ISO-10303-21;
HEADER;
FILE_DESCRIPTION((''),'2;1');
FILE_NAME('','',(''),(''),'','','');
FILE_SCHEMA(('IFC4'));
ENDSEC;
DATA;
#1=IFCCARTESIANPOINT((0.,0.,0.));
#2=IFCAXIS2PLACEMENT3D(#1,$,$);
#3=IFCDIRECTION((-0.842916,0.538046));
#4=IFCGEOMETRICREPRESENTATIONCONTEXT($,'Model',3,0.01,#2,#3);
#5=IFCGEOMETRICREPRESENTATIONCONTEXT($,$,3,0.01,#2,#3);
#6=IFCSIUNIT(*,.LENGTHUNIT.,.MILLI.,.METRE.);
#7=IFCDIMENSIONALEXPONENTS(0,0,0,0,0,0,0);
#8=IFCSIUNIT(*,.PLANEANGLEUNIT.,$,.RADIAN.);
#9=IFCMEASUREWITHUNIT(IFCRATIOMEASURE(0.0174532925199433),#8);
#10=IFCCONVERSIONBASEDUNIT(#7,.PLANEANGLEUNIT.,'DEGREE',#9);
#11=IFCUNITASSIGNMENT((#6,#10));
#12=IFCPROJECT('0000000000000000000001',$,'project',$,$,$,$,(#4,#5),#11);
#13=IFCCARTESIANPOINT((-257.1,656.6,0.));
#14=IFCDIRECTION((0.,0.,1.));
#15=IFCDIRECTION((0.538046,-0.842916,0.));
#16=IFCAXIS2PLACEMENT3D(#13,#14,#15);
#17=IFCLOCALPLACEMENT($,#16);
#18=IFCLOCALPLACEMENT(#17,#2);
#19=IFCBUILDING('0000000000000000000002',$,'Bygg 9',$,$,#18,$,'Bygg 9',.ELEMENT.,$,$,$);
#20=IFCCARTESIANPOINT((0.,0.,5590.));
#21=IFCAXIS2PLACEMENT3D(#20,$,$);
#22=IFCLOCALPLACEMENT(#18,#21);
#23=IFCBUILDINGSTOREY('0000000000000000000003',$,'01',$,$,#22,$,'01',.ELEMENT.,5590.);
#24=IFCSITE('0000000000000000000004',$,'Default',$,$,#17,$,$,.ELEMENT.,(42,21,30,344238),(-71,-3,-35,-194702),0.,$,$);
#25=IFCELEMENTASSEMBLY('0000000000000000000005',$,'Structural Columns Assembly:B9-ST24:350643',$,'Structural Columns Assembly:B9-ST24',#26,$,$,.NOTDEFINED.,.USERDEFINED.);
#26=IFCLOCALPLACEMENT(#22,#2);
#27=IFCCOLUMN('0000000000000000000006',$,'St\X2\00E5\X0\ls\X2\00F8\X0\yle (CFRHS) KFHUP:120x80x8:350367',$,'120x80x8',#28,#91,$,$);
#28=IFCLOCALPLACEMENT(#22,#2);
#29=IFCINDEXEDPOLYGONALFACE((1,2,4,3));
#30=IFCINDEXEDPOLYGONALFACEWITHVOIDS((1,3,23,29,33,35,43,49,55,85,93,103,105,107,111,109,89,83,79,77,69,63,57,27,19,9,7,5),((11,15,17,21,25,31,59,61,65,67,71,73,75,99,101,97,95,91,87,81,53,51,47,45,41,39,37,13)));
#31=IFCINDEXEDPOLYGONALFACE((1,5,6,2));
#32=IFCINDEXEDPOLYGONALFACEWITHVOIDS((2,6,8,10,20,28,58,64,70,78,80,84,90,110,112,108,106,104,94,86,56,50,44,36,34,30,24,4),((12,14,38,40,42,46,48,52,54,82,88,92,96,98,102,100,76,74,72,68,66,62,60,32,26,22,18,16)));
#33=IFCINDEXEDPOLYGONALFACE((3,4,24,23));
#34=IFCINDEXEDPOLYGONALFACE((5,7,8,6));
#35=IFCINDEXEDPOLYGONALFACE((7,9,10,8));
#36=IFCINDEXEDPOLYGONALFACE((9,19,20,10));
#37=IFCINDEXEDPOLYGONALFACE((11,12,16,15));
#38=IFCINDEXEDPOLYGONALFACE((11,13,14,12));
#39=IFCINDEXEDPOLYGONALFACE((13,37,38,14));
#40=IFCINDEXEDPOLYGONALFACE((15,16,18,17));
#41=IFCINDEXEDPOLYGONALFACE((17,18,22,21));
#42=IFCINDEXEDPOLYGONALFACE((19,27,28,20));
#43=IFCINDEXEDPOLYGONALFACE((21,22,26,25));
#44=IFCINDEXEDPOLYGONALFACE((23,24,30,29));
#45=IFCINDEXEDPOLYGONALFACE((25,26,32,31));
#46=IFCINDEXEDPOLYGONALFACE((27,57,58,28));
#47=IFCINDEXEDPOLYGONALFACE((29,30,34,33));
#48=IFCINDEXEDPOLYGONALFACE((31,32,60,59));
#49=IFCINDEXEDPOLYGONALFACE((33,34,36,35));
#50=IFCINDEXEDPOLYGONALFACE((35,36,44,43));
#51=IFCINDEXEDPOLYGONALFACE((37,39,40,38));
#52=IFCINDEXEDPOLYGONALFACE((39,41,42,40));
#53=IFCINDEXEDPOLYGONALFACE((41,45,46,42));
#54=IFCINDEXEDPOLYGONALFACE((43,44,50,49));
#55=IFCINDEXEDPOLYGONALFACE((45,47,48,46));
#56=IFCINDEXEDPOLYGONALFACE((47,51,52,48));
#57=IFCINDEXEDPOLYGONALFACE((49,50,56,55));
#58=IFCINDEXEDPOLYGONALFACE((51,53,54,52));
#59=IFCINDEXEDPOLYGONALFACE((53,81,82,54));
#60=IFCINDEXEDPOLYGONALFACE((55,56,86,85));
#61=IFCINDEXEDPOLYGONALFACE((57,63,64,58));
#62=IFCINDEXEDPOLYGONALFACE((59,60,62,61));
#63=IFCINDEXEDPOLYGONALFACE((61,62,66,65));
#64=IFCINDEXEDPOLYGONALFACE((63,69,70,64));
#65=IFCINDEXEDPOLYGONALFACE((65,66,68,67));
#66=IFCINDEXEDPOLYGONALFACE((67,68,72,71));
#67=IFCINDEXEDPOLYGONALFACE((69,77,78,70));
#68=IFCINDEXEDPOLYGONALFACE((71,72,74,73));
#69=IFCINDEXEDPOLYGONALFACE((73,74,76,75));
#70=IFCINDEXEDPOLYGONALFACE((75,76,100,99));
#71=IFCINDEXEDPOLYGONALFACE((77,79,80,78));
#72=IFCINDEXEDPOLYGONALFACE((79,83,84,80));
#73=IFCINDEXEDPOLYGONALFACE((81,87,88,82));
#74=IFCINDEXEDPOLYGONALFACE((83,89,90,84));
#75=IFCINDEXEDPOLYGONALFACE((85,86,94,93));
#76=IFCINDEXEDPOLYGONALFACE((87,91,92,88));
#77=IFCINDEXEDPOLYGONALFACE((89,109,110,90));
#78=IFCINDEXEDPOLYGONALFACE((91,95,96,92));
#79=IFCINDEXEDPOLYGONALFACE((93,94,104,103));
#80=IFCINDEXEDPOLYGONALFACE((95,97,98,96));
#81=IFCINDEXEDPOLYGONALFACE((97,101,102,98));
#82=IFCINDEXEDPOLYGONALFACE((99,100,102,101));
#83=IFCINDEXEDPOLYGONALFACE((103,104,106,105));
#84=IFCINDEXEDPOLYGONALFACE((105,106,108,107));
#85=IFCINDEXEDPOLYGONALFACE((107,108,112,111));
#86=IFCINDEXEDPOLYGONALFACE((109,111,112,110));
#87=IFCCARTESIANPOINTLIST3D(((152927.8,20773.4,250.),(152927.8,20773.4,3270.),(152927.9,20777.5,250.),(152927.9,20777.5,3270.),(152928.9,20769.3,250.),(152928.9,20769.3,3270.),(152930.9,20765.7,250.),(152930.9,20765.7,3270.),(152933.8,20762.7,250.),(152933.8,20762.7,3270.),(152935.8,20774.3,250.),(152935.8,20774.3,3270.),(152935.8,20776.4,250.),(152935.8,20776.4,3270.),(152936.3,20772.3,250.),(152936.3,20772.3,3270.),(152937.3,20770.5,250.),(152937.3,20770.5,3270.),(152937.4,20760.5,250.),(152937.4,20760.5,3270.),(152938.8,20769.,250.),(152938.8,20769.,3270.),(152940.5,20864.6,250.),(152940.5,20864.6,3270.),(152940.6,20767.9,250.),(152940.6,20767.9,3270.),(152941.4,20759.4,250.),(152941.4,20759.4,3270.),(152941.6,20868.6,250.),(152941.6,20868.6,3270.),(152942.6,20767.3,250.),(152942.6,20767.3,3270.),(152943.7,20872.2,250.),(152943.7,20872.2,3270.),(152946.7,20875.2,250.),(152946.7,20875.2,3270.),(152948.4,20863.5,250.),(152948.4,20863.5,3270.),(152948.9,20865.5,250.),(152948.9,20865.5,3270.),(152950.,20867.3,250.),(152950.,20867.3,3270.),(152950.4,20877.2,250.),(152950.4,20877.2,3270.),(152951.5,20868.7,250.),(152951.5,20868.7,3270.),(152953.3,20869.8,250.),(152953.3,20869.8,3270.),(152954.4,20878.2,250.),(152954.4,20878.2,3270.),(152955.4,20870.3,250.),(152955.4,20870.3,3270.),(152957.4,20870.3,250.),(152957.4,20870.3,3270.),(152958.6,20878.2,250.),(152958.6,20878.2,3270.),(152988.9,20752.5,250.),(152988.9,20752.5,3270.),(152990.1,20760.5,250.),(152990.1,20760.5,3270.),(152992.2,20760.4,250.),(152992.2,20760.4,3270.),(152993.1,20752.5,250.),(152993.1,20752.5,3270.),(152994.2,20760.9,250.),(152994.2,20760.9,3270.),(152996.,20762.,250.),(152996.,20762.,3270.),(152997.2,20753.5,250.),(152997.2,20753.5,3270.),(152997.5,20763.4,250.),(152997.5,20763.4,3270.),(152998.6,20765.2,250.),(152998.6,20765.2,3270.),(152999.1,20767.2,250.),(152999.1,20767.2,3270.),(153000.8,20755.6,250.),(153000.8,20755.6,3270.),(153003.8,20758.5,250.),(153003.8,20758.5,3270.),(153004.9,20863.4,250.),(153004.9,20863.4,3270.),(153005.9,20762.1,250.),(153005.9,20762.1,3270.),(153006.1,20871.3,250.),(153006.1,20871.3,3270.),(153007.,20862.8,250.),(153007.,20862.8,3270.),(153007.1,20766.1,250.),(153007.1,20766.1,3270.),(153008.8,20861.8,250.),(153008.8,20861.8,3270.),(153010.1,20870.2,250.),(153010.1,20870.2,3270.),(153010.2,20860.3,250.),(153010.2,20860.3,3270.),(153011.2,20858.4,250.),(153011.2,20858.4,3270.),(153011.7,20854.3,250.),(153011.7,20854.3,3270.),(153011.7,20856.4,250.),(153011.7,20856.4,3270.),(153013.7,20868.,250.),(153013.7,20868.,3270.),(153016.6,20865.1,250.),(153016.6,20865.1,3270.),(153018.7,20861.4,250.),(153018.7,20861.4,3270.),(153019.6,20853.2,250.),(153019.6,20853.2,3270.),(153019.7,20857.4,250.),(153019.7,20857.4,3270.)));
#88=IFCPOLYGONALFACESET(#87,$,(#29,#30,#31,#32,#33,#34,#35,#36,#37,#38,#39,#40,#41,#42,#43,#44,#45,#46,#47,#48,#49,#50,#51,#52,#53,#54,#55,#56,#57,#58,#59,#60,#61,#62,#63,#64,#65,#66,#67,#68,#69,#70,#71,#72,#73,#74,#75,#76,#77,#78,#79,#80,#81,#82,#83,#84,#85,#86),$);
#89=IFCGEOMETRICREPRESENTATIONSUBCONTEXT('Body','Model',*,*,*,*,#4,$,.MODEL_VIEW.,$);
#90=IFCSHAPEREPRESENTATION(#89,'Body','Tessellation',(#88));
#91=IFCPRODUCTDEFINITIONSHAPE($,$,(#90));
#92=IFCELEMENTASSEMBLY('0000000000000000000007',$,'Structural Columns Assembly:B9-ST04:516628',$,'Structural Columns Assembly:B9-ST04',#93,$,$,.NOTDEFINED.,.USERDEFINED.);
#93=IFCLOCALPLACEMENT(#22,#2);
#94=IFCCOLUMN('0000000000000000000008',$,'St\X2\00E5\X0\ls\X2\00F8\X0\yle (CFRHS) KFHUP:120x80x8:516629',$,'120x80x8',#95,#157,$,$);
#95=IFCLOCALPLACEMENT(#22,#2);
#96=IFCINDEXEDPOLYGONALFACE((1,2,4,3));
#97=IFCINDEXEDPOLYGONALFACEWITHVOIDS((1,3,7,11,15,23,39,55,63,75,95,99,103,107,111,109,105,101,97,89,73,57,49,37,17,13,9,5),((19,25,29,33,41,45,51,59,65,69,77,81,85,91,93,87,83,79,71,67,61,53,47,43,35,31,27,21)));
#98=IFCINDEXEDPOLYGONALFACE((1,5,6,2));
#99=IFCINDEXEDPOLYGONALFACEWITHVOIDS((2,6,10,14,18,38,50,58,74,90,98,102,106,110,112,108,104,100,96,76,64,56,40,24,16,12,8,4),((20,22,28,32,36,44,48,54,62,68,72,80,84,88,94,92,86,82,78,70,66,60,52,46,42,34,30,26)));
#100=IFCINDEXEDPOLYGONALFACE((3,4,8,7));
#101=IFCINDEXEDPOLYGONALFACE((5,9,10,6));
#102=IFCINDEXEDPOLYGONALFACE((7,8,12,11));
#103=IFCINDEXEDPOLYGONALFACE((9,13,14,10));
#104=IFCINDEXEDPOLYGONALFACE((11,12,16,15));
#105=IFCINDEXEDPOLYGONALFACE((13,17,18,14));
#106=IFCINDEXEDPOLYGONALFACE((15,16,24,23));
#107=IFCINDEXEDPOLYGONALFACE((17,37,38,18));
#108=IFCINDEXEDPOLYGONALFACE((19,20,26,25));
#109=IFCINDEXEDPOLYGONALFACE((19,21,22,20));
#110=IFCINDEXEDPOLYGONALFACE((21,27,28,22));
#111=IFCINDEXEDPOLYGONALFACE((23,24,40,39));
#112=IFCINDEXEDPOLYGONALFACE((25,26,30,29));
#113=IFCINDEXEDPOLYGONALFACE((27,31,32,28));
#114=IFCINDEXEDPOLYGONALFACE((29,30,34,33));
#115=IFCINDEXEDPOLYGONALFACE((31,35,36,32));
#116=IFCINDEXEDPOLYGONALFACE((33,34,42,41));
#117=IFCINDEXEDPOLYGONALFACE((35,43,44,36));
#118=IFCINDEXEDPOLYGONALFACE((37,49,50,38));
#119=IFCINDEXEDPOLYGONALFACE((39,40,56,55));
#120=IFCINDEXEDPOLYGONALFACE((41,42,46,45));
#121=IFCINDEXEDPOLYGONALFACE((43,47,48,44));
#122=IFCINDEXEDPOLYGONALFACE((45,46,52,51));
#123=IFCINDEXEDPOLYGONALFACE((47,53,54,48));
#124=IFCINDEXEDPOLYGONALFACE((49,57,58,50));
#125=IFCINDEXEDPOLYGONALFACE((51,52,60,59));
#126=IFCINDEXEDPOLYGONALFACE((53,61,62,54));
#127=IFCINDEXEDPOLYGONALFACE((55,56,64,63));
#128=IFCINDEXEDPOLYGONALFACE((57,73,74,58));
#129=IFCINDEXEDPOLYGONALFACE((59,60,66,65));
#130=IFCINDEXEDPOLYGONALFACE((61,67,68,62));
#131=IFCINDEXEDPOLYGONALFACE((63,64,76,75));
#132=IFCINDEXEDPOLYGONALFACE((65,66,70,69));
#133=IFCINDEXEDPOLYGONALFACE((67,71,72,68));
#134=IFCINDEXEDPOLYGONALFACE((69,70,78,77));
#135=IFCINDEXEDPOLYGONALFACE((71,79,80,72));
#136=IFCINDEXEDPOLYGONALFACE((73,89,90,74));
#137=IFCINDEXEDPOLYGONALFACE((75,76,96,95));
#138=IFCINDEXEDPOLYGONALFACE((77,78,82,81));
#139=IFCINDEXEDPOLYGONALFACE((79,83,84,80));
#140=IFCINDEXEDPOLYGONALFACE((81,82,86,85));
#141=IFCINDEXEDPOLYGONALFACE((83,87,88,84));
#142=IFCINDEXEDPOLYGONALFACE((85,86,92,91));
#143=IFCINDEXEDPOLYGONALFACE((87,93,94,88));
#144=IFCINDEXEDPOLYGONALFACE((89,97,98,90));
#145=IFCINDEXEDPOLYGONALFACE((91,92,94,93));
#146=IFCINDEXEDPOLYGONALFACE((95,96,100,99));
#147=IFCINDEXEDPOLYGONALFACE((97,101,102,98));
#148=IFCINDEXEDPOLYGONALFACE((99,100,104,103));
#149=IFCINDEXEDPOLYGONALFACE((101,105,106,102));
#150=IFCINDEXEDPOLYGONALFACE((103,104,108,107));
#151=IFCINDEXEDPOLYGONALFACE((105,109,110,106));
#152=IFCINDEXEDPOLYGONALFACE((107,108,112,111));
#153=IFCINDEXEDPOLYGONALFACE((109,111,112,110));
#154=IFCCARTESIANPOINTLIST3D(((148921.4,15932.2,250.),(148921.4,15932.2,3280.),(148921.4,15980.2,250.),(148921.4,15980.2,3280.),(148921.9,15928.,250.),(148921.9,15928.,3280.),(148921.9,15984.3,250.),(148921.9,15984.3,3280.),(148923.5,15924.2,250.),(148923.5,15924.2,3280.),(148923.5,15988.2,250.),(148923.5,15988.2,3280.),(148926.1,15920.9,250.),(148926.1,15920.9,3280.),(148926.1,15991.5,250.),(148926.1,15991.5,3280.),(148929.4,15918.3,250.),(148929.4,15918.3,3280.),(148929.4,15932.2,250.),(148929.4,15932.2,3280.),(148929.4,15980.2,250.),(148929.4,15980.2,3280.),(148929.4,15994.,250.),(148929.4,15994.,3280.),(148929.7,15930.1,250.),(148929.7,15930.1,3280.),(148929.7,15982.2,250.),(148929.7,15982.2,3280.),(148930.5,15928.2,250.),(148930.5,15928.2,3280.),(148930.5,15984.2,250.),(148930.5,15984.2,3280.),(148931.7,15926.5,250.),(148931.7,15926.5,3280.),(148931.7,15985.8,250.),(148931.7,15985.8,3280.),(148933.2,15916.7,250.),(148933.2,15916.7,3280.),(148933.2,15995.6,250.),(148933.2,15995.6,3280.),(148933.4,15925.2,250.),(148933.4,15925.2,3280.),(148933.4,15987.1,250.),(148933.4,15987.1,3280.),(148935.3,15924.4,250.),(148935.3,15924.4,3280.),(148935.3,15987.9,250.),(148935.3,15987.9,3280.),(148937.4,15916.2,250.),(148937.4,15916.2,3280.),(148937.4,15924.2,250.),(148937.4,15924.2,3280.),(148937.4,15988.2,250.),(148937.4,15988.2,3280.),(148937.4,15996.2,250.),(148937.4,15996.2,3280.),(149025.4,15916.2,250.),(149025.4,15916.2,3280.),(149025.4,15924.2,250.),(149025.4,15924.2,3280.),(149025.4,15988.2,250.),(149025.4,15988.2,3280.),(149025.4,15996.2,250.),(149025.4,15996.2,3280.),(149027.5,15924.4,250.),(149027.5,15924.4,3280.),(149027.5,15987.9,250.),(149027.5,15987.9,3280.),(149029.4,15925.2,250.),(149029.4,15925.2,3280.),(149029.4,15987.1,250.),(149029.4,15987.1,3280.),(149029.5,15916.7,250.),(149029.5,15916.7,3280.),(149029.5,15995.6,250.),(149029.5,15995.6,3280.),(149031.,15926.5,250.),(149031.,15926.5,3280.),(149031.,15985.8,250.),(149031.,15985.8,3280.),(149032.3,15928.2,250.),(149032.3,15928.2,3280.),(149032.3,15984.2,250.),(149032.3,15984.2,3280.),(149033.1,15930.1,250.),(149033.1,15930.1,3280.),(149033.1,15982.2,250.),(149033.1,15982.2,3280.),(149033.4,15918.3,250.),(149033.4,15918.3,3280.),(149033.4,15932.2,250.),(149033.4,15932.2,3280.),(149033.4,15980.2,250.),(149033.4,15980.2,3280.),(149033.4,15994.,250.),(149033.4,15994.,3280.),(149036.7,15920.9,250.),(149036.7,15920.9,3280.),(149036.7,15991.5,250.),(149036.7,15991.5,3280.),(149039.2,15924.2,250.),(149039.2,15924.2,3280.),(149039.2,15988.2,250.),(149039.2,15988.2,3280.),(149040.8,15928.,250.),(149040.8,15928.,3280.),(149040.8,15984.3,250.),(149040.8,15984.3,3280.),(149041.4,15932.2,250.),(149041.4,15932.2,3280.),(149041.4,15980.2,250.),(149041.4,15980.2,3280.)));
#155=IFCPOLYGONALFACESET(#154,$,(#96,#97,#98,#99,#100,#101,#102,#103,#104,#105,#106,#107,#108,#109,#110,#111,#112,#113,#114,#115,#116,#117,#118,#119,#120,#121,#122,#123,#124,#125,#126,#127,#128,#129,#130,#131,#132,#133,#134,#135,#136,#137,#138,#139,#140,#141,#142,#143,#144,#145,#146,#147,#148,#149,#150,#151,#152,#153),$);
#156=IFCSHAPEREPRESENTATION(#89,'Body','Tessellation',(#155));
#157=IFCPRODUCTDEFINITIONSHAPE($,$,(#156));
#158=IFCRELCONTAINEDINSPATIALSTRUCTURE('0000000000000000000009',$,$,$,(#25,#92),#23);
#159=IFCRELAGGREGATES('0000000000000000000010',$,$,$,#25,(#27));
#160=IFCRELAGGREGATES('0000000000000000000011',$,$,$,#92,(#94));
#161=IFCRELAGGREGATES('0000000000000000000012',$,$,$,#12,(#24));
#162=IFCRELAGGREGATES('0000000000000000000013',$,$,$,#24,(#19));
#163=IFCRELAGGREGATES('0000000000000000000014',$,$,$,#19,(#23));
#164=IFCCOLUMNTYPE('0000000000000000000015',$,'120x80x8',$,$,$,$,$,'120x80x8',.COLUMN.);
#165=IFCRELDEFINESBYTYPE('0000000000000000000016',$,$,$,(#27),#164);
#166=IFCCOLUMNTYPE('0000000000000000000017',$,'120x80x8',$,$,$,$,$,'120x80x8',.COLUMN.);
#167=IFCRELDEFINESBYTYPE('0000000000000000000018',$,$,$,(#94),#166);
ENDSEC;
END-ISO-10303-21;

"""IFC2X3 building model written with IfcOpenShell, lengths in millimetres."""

from ifc_helpers import new_model, entity, si_unit, converted_unit, direction, frame, frame_2d, origin, place, context, subcontext, project, spatial, polyline, circle_curve, parameter, trimmed, segment, composite_curve, outline, extrude, source, transform, mapped, type_object, type_shapes, element, aggregate, save


model = new_model("IFC2X3")

# Units and contexts
model_context = context("Model", 3, precision=0.01, world=origin(), true_north=direction((-0.842916, 0.538046)))
context_of_model = context(None, 3, precision=0.01, world=origin(), true_north=direction((-0.842916, 0.538046)))
body_context = subcontext(model_context, "Body", "Model", "MODEL_VIEW")
ifc_project = project(units=[si_unit("LENGTHUNIT", "METRE", prefix="MILLI"), converted_unit("PLANEANGLEUNIT", "DEGREE", entity("IfcRatioMeasure", 0.0174532925199433), si_unit("PLANEANGLEUNIT", "RADIAN"), dimensions=[0, 0, 0, 0, 0, 0, 0])], contexts=[model_context, context_of_model])

# Site, building, storey
site_placement = place(None, frame((-257.1, 656.6, 0.0), z_axis=(0.0, 0.0, 1.0), x_axis=(0.538046, -0.842916, 0.0)))
site = spatial("IfcSite", under=ifc_project, at=site_placement, Name="Default", CompositionType="ELEMENT", RefLatitude=(42, 21, 30, 344238), RefLongitude=(-71, -3, -35, -194702), RefElevation=0.0)
building_placement = place(site_placement, origin())
building = spatial("IfcBuilding", under=site, at=building_placement, Name="Bygg 9", LongName="Bygg 9", CompositionType="ELEMENT")
storey_placement = place(building_placement, frame((0.0, 0.0, 5590.0)))
storey = spatial("IfcBuildingStorey", under=building, at=storey_placement, Name="01", LongName="01", CompositionType="ELEMENT", Elevation=5590.0)

# Element assemblies, columns
assembly_1_placement = place(storey_placement, origin())
assembly_1 = element("IfcElementAssembly", 1, at=assembly_1_placement, inside=storey, Name="Structural Columns Assembly:B9-ST24:350643", ObjectType="Structural Columns Assembly:B9-ST24", AssemblyPlace="NOTDEFINED", PredefinedType="USERDEFINED")
column_type_1 = type_object("IfcColumnType", Name="120x80x8", ElementType="120x80x8", PredefinedType="COLUMN")
shared_shape_1 = source(origin(), body_context, "Body", "SweptSolid", [
    extrude(outline(composite_curve([segment(polyline([(-24.0, -60.0), (24.0, -60.0)]), True, "CONTINUOUS"), segment(trimmed(circle_curve(frame_2d((24.0, -44.0), x_axis=(-1.0, 0.0)), 16.0), [parameter(90.0)], [parameter(180.0)], True, "PARAMETER"), True, "CONTINUOUS"), segment(polyline([(40.0, -44.0), (40.0, 44.0)]), True, "CONTINUOUS"), segment(trimmed(circle_curve(frame_2d((24.0, 44.0), x_axis=(-1.0, 0.0)), 16.0), [parameter(180.0)], [parameter(270.0)], True, "PARAMETER"), True, "CONTINUOUS"), segment(polyline([(24.0, 60.0), (-24.0, 60.0)]), True, "CONTINUOUS"), segment(trimmed(circle_curve(frame_2d((-24.0, 44.0), x_axis=(-1.0, 0.0)), 16.0), [parameter(270.0)], [parameter(0.0)], True, "PARAMETER"), True, "CONTINUOUS"), segment(polyline([(-40.0, 44.0), (-40.0, -44.0)]), True, "CONTINUOUS"), segment(trimmed(circle_curve(frame_2d((-24.0, -44.0), x_axis=(-1.0, 0.0)), 16.0), [parameter(0.0)], [parameter(90.0)], True, "PARAMETER"), True, "CONTINUOUS")], self_intersect=False), holes=[composite_curve([segment(trimmed(circle_curve(frame_2d((24.0, -44.0), x_axis=(-1.0, 0.0)), 8.0), [parameter(90.0)], [parameter(180.0)], True, "PARAMETER"), False, "CONTINUOUS"), segment(polyline([(24.0, -52.0), (-24.0, -52.0)]), True, "CONTINUOUS"), segment(trimmed(circle_curve(frame_2d((-24.0, -44.0), x_axis=(-1.0, 0.0)), 8.0), [parameter(360.0)], [parameter(90.0)], True, "PARAMETER"), False, "CONTINUOUS"), segment(polyline([(-32.0, -44.0), (-32.0, 44.0)]), True, "CONTINUOUS"), segment(trimmed(circle_curve(frame_2d((-24.0, 44.0), x_axis=(-1.0, 0.0)), 8.0), [parameter(270.0)], [parameter(360.0)], True, "PARAMETER"), False, "CONTINUOUS"), segment(polyline([(-24.0, 52.0), (24.0, 52.0)]), True, "CONTINUOUS"), segment(trimmed(circle_curve(frame_2d((24.0, 44.0), x_axis=(-1.0, 0.0)), 8.0), [parameter(180.0)], [parameter(270.0)], True, "PARAMETER"), False, "CONTINUOUS"), segment(polyline([(32.0, 44.0), (32.0, -44.0)]), True, "CONTINUOUS")], self_intersect=False)]), frame((47.5, 64.4, 0.0), z_axis=(0.0, 0.0, 1.0), x_axis=(0.989719, -0.143028, 0.0)), (0.0, 0.0, 1.0), 3020.0),
])
type_shapes(column_type_1, [shared_shape_1])
column_1_placement = place(assembly_1_placement, frame((152926.3, 20750.9, 250.0)))
column_1 = element("IfcColumn", 2, at=column_1_placement, type_object=column_type_1, Name="Stålsøyle (CFRHS) KFHUP:120x80x8:350367", ObjectType="120x80x8", context=body_context, shape_type="MappedRepresentation", body=[
    mapped(shared_shape_1, transform((0.0, 0.0, 0.0), scale=1.0)),
])
aggregate(assembly_1, [column_1])
assembly_2_placement = place(storey_placement, origin())
assembly_2 = element("IfcElementAssembly", 3, at=assembly_2_placement, inside=storey, Name="Structural Columns Assembly:B9-ST04:516628", ObjectType="Structural Columns Assembly:B9-ST04", AssemblyPlace="NOTDEFINED", PredefinedType="USERDEFINED")
column_type_2 = type_object("IfcColumnType", Name="120x80x8", ElementType="120x80x8", PredefinedType="COLUMN")
shared_shape_2 = source(origin(), body_context, "Body", "SweptSolid", [
    extrude(outline(composite_curve([segment(trimmed(circle_curve(frame_2d((-24.0, 44.0), x_axis=(1.0, 0.0)), 16.0), [parameter(90.0)], [parameter(180.0)], True, "PARAMETER"), True, "CONTINUOUS"), segment(polyline([(-40.0, 44.0), (-40.0, -44.0)]), True, "CONTINUOUS"), segment(trimmed(circle_curve(frame_2d((-24.0, -44.0), x_axis=(1.0, 0.0)), 16.0), [parameter(180.0)], [parameter(270.0)], True, "PARAMETER"), True, "CONTINUOUS"), segment(polyline([(-24.0, -60.0), (24.0, -60.0)]), True, "CONTINUOUS"), segment(trimmed(circle_curve(frame_2d((24.0, -44.0), x_axis=(1.0, 0.0)), 16.0), [parameter(270.0)], [parameter(0.0)], True, "PARAMETER"), True, "CONTINUOUS"), segment(polyline([(40.0, -44.0), (40.0, 44.0)]), True, "CONTINUOUS"), segment(trimmed(circle_curve(frame_2d((24.0, 44.0), x_axis=(1.0, 0.0)), 16.0), [parameter(0.0)], [parameter(90.0)], True, "PARAMETER"), True, "CONTINUOUS"), segment(polyline([(24.0, 60.0), (-24.0, 60.0)]), True, "CONTINUOUS")], self_intersect=False), holes=[composite_curve([segment(polyline([(-24.0, 52.0), (24.0, 52.0)]), True, "CONTINUOUS"), segment(trimmed(circle_curve(frame_2d((24.0, 44.0), x_axis=(1.0, 0.0)), 8.0), [parameter(360.0)], [parameter(90.0)], True, "PARAMETER"), False, "CONTINUOUS"), segment(polyline([(32.0, 44.0), (32.0, -44.0)]), True, "CONTINUOUS"), segment(trimmed(circle_curve(frame_2d((24.0, -44.0), x_axis=(1.0, 0.0)), 8.0), [parameter(270.0)], [parameter(360.0)], True, "PARAMETER"), False, "CONTINUOUS"), segment(polyline([(24.0, -52.0), (-24.0, -52.0)]), True, "CONTINUOUS"), segment(trimmed(circle_curve(frame_2d((-24.0, -44.0), x_axis=(1.0, 0.0)), 8.0), [parameter(180.0)], [parameter(270.0)], True, "PARAMETER"), False, "CONTINUOUS"), segment(polyline([(-32.0, -44.0), (-32.0, 44.0)]), True, "CONTINUOUS"), segment(trimmed(circle_curve(frame_2d((-24.0, 44.0), x_axis=(1.0, 0.0)), 8.0), [parameter(90.0)], [parameter(180.0)], True, "PARAMETER"), False, "CONTINUOUS")], self_intersect=False)]), frame((41.6, 61.6, 0.0), z_axis=(0.0, 0.0, 1.0), x_axis=(-1.0, 0.0, 0.0)), (0.0, 0.0, 1.0), 3030.0),
])
type_shapes(column_type_2, [shared_shape_2])
column_2_placement = place(assembly_2_placement, frame((149043.0, 15914.6, 250.0), z_axis=(0.0, 0.0, 1.0), x_axis=(0.0, 1.0, 0.0)))
column_2 = element("IfcColumn", 4, at=column_2_placement, type_object=column_type_2, Name="Stålsøyle (CFRHS) KFHUP:120x80x8:516629", ObjectType="120x80x8", context=body_context, shape_type="MappedRepresentation", body=[
    mapped(shared_shape_2, transform((0.0, 0.0, 0.0), scale=1.0)),
])

aggregate(assembly_2, [column_2])

save(model, "model.ifc")
